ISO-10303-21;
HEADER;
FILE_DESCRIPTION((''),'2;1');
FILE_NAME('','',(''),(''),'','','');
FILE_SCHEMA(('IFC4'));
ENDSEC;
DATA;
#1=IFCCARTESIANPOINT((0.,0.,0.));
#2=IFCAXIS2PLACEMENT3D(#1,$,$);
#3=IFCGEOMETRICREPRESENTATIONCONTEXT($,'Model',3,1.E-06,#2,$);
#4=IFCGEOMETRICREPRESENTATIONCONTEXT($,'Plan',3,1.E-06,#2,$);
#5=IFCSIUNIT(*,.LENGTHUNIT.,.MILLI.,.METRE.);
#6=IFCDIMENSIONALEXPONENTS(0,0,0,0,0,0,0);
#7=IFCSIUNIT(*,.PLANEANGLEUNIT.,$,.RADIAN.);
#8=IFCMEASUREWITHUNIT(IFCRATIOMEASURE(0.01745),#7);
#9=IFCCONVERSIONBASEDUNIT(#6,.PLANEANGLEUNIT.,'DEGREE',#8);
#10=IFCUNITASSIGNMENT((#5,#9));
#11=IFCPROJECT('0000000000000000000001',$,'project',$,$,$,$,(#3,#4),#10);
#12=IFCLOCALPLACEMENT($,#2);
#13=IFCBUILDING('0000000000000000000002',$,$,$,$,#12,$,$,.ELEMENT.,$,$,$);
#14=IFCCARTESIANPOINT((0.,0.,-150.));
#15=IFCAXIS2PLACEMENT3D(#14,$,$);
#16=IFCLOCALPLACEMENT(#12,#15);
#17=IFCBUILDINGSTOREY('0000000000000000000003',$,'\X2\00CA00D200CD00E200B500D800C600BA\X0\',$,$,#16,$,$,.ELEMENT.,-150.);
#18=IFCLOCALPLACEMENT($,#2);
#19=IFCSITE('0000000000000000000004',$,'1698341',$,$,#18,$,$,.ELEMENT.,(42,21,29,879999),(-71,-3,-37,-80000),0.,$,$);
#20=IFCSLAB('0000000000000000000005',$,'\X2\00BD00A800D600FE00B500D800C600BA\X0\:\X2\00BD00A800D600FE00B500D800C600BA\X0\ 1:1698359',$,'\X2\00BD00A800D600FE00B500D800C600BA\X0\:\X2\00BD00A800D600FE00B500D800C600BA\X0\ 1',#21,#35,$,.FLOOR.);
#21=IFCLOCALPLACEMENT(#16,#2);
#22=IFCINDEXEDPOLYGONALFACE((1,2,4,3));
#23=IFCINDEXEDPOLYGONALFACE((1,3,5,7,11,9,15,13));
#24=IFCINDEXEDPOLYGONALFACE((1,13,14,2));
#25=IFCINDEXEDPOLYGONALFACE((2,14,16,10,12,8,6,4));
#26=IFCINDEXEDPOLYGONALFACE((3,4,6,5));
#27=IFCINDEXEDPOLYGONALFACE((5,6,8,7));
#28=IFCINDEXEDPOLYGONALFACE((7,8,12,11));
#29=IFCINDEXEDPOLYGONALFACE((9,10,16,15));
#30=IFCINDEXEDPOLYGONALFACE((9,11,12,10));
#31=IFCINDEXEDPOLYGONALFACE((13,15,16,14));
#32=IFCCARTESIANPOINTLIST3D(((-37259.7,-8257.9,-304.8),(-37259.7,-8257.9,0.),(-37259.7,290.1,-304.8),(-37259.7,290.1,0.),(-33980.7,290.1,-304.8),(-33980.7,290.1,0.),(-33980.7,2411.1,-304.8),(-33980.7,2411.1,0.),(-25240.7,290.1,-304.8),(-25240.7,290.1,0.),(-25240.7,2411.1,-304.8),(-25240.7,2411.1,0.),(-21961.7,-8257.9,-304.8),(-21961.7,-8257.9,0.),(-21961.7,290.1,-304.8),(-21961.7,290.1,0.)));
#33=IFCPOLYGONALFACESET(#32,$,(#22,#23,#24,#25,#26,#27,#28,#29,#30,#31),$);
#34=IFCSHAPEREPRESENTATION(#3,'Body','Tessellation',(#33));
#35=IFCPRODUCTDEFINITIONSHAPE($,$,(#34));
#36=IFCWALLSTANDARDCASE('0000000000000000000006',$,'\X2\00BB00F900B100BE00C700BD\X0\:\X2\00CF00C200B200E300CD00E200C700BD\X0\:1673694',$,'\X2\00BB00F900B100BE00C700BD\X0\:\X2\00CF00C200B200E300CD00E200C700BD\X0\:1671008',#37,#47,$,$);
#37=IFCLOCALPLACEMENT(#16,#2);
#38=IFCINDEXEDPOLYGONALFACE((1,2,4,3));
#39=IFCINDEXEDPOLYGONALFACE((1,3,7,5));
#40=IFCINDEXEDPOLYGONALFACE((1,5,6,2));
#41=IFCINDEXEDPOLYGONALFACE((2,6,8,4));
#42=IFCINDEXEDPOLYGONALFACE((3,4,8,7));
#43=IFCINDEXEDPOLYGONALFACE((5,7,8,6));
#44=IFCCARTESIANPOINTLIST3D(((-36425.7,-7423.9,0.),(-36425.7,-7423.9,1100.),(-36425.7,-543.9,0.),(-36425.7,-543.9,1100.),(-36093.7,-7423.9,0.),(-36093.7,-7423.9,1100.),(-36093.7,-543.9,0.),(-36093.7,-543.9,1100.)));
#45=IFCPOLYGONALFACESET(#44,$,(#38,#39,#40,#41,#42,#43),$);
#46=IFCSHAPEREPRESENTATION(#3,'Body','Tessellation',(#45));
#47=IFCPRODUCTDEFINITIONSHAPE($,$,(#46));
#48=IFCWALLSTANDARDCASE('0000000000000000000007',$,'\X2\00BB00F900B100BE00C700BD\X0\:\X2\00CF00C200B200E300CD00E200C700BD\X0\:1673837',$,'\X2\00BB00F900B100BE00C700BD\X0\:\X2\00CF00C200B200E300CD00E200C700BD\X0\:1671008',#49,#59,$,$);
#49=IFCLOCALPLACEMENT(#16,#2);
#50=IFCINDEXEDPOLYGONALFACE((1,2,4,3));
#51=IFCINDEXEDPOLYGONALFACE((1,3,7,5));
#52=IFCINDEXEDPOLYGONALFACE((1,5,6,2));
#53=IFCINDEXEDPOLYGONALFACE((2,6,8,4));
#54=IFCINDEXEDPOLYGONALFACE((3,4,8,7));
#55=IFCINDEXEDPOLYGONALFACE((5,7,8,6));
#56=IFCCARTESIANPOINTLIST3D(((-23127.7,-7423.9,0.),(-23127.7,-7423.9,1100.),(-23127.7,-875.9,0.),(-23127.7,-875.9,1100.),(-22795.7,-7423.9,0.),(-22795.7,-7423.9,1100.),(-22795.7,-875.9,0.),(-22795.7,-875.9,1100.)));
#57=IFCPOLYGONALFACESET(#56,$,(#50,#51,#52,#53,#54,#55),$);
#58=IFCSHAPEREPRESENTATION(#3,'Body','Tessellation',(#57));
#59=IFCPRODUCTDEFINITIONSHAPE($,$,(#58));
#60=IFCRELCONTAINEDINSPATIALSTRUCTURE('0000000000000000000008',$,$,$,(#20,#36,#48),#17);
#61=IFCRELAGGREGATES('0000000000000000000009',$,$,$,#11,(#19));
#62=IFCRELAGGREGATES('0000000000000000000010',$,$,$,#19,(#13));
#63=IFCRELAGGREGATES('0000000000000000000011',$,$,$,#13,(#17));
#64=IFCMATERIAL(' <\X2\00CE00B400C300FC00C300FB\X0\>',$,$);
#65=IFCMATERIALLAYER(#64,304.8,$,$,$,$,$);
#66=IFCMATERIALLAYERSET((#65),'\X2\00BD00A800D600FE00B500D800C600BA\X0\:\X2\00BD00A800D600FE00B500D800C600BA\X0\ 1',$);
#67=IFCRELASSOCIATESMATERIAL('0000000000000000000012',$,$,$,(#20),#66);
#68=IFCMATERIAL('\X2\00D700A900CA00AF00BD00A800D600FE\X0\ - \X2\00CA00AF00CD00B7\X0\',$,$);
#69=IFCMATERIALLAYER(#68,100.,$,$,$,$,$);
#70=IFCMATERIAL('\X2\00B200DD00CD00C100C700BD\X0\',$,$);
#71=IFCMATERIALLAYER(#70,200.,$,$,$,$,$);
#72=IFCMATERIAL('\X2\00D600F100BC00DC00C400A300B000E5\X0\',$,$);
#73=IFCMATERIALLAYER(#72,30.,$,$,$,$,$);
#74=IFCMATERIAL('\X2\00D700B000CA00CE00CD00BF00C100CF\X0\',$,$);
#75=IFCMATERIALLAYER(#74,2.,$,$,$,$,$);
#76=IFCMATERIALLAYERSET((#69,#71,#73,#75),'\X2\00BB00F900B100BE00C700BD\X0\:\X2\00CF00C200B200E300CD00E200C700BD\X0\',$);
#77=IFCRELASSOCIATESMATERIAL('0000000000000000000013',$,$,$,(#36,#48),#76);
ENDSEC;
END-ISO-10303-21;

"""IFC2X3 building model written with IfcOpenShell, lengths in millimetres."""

from ifc_helpers import new_model, entity, si_unit, converted_unit, frame, frame_2d, origin, place, context, project, spatial, polyline, rectangle, outline, extrude, material, layer, layer_set, layer_usage, element, save


model = new_model("IFC2X3")

# Units and contexts
model_context = context("Model", 3, precision=1e-06, world=origin())
plan_context = context("Plan", 3, precision=1e-06, world=origin())
ifc_project = project(units=[si_unit("LENGTHUNIT", "METRE", prefix="MILLI"), converted_unit("PLANEANGLEUNIT", "DEGREE", entity("IfcRatioMeasure", 0.01745), si_unit("PLANEANGLEUNIT", "RADIAN"), dimensions=[0, 0, 0, 0, 0, 0, 0])], contexts=[model_context, plan_context])

# Site, building, storey
site_placement = place(None, origin())
site = spatial("IfcSite", under=ifc_project, at=site_placement, Name="1698341", CompositionType="ELEMENT", RefLatitude=(42, 21, 29, 879999), RefLongitude=(-71, -3, -37, -80000), RefElevation=0.0)
building_placement = place(None, origin())
building = spatial("IfcBuilding", under=site, at=building_placement, CompositionType="ELEMENT")
storey_placement = place(building_placement, frame((0.0, 0.0, -150.0)))
storey = spatial("IfcBuildingStorey", under=building, at=storey_placement, Name="ÊÒÍâµØÆº", CompositionType="ELEMENT", Elevation=-150.0)

# Slab
ifc_material_1 = material(Name=" <Î´ÃüÃû>")
ifc_layer_1 = layer(ifc_material_1, 304.8)
ifc_layer_set_1 = layer_set([ifc_layer_1], Name="½¨ÖþµØÆº:½¨ÖþµØÆº 1")
ifc_layer_usage_1 = layer_usage(ifc_layer_set_1, "AXIS3", "NEGATIVE", 0.0)
slab_placement = place(storey_placement, frame((-37259.7, -8257.9, -304.8)))
element("IfcSlab", 1, at=slab_placement, inside=storey, material=ifc_layer_usage_1, Name="½¨ÖþµØÆº:½¨ÖþµØÆº 1:1698359", ObjectType="½¨ÖþµØÆº:½¨ÖþµØÆº 1", PredefinedType="FLOOR", context=model_context, shape_type="SweptSolid", body=[
    extrude(outline(polyline([(7649.0, 3213.5), (4370.0, 3213.5), (4370.0, 5334.5), (-4370.0, 5334.5), (-4370.0, 3213.5), (-7649.0, 3213.5), (-7649.0, -5334.5), (7649.0, -5334.5), (7649.0, 3213.5)])), frame((7649.0, 5334.5, 304.8), z_axis=(0.0, 0.0, -1.0), x_axis=(-1.0, 0.0, 0.0)), (0.0, 0.0, 1.0), 304.8),
])

# Wall
ifc_material_2 = material(Name="×©Ê¯½¨Öþ - Ê¯Í·")
ifc_layer_2 = layer(ifc_material_2, 100.0)
ifc_material_3 = material(Name="²ÝÍÁÇ½")
ifc_layer_3 = layer(ifc_material_3, 200.0)
ifc_material_4 = material(Name="Öñ¼ÜÄ£°å")
ifc_layer_4 = layer(ifc_material_4, 30.0)
ifc_material_5 = material(Name="×°ÊÎÍ¿ÁÏ")
ifc_layer_5 = layer(ifc_material_5, 2.0)
ifc_layer_set_2 = layer_set([ifc_layer_2, ifc_layer_3, ifc_layer_4, ifc_layer_5], Name="»ù±¾Ç½:ÏÂ²ãÍâÇ½")
ifc_layer_usage_2 = layer_usage(ifc_layer_set_2, "AXIS2", "NEGATIVE", 166.0)
wall_1_placement = place(storey_placement, frame((-36259.7, -7423.9, 0.0), z_axis=(0.0, 0.0, 1.0), x_axis=(0.0, 1.0, 0.0)))
element("IfcWallStandardCase", 2, at=wall_1_placement, inside=storey, material=ifc_layer_usage_2, Name="»ù±¾Ç½:ÏÂ²ãÍâÇ½:1673694", ObjectType="»ù±¾Ç½:ÏÂ²ãÍâÇ½:1671008", context=model_context, shape_type="SweptSolid", body=[
    extrude(rectangle(XDim=6880.0, YDim=332.0, at=frame_2d((3440.0, 0.0), x_axis=(-1.0, 0.0))), origin(), (0.0, 0.0, 1.0), 1100.0),
])

# Wall
ifc_layer_usage_3 = layer_usage(ifc_layer_set_2, "AXIS2", "NEGATIVE", 166.0)
wall_2_placement = place(storey_placement, frame((-22961.7, -875.9, 0.0), z_axis=(0.0, 0.0, 1.0), x_axis=(0.0, -1.0, 0.0)))
element("IfcWallStandardCase", 3, at=wall_2_placement, inside=storey, material=ifc_layer_usage_3, Name="»ù±¾Ç½:ÏÂ²ãÍâÇ½:1673837", ObjectType="»ù±¾Ç½:ÏÂ²ãÍâÇ½:1671008", context=model_context, shape_type="SweptSolid", body=[
    extrude(rectangle(XDim=6548.0, YDim=332.0, at=frame_2d((3274.0, 0.0), x_axis=(-1.0, 0.0))), origin(), (0.0, 0.0, 1.0), 1100.0),
])

save(model, "model.ifc")
